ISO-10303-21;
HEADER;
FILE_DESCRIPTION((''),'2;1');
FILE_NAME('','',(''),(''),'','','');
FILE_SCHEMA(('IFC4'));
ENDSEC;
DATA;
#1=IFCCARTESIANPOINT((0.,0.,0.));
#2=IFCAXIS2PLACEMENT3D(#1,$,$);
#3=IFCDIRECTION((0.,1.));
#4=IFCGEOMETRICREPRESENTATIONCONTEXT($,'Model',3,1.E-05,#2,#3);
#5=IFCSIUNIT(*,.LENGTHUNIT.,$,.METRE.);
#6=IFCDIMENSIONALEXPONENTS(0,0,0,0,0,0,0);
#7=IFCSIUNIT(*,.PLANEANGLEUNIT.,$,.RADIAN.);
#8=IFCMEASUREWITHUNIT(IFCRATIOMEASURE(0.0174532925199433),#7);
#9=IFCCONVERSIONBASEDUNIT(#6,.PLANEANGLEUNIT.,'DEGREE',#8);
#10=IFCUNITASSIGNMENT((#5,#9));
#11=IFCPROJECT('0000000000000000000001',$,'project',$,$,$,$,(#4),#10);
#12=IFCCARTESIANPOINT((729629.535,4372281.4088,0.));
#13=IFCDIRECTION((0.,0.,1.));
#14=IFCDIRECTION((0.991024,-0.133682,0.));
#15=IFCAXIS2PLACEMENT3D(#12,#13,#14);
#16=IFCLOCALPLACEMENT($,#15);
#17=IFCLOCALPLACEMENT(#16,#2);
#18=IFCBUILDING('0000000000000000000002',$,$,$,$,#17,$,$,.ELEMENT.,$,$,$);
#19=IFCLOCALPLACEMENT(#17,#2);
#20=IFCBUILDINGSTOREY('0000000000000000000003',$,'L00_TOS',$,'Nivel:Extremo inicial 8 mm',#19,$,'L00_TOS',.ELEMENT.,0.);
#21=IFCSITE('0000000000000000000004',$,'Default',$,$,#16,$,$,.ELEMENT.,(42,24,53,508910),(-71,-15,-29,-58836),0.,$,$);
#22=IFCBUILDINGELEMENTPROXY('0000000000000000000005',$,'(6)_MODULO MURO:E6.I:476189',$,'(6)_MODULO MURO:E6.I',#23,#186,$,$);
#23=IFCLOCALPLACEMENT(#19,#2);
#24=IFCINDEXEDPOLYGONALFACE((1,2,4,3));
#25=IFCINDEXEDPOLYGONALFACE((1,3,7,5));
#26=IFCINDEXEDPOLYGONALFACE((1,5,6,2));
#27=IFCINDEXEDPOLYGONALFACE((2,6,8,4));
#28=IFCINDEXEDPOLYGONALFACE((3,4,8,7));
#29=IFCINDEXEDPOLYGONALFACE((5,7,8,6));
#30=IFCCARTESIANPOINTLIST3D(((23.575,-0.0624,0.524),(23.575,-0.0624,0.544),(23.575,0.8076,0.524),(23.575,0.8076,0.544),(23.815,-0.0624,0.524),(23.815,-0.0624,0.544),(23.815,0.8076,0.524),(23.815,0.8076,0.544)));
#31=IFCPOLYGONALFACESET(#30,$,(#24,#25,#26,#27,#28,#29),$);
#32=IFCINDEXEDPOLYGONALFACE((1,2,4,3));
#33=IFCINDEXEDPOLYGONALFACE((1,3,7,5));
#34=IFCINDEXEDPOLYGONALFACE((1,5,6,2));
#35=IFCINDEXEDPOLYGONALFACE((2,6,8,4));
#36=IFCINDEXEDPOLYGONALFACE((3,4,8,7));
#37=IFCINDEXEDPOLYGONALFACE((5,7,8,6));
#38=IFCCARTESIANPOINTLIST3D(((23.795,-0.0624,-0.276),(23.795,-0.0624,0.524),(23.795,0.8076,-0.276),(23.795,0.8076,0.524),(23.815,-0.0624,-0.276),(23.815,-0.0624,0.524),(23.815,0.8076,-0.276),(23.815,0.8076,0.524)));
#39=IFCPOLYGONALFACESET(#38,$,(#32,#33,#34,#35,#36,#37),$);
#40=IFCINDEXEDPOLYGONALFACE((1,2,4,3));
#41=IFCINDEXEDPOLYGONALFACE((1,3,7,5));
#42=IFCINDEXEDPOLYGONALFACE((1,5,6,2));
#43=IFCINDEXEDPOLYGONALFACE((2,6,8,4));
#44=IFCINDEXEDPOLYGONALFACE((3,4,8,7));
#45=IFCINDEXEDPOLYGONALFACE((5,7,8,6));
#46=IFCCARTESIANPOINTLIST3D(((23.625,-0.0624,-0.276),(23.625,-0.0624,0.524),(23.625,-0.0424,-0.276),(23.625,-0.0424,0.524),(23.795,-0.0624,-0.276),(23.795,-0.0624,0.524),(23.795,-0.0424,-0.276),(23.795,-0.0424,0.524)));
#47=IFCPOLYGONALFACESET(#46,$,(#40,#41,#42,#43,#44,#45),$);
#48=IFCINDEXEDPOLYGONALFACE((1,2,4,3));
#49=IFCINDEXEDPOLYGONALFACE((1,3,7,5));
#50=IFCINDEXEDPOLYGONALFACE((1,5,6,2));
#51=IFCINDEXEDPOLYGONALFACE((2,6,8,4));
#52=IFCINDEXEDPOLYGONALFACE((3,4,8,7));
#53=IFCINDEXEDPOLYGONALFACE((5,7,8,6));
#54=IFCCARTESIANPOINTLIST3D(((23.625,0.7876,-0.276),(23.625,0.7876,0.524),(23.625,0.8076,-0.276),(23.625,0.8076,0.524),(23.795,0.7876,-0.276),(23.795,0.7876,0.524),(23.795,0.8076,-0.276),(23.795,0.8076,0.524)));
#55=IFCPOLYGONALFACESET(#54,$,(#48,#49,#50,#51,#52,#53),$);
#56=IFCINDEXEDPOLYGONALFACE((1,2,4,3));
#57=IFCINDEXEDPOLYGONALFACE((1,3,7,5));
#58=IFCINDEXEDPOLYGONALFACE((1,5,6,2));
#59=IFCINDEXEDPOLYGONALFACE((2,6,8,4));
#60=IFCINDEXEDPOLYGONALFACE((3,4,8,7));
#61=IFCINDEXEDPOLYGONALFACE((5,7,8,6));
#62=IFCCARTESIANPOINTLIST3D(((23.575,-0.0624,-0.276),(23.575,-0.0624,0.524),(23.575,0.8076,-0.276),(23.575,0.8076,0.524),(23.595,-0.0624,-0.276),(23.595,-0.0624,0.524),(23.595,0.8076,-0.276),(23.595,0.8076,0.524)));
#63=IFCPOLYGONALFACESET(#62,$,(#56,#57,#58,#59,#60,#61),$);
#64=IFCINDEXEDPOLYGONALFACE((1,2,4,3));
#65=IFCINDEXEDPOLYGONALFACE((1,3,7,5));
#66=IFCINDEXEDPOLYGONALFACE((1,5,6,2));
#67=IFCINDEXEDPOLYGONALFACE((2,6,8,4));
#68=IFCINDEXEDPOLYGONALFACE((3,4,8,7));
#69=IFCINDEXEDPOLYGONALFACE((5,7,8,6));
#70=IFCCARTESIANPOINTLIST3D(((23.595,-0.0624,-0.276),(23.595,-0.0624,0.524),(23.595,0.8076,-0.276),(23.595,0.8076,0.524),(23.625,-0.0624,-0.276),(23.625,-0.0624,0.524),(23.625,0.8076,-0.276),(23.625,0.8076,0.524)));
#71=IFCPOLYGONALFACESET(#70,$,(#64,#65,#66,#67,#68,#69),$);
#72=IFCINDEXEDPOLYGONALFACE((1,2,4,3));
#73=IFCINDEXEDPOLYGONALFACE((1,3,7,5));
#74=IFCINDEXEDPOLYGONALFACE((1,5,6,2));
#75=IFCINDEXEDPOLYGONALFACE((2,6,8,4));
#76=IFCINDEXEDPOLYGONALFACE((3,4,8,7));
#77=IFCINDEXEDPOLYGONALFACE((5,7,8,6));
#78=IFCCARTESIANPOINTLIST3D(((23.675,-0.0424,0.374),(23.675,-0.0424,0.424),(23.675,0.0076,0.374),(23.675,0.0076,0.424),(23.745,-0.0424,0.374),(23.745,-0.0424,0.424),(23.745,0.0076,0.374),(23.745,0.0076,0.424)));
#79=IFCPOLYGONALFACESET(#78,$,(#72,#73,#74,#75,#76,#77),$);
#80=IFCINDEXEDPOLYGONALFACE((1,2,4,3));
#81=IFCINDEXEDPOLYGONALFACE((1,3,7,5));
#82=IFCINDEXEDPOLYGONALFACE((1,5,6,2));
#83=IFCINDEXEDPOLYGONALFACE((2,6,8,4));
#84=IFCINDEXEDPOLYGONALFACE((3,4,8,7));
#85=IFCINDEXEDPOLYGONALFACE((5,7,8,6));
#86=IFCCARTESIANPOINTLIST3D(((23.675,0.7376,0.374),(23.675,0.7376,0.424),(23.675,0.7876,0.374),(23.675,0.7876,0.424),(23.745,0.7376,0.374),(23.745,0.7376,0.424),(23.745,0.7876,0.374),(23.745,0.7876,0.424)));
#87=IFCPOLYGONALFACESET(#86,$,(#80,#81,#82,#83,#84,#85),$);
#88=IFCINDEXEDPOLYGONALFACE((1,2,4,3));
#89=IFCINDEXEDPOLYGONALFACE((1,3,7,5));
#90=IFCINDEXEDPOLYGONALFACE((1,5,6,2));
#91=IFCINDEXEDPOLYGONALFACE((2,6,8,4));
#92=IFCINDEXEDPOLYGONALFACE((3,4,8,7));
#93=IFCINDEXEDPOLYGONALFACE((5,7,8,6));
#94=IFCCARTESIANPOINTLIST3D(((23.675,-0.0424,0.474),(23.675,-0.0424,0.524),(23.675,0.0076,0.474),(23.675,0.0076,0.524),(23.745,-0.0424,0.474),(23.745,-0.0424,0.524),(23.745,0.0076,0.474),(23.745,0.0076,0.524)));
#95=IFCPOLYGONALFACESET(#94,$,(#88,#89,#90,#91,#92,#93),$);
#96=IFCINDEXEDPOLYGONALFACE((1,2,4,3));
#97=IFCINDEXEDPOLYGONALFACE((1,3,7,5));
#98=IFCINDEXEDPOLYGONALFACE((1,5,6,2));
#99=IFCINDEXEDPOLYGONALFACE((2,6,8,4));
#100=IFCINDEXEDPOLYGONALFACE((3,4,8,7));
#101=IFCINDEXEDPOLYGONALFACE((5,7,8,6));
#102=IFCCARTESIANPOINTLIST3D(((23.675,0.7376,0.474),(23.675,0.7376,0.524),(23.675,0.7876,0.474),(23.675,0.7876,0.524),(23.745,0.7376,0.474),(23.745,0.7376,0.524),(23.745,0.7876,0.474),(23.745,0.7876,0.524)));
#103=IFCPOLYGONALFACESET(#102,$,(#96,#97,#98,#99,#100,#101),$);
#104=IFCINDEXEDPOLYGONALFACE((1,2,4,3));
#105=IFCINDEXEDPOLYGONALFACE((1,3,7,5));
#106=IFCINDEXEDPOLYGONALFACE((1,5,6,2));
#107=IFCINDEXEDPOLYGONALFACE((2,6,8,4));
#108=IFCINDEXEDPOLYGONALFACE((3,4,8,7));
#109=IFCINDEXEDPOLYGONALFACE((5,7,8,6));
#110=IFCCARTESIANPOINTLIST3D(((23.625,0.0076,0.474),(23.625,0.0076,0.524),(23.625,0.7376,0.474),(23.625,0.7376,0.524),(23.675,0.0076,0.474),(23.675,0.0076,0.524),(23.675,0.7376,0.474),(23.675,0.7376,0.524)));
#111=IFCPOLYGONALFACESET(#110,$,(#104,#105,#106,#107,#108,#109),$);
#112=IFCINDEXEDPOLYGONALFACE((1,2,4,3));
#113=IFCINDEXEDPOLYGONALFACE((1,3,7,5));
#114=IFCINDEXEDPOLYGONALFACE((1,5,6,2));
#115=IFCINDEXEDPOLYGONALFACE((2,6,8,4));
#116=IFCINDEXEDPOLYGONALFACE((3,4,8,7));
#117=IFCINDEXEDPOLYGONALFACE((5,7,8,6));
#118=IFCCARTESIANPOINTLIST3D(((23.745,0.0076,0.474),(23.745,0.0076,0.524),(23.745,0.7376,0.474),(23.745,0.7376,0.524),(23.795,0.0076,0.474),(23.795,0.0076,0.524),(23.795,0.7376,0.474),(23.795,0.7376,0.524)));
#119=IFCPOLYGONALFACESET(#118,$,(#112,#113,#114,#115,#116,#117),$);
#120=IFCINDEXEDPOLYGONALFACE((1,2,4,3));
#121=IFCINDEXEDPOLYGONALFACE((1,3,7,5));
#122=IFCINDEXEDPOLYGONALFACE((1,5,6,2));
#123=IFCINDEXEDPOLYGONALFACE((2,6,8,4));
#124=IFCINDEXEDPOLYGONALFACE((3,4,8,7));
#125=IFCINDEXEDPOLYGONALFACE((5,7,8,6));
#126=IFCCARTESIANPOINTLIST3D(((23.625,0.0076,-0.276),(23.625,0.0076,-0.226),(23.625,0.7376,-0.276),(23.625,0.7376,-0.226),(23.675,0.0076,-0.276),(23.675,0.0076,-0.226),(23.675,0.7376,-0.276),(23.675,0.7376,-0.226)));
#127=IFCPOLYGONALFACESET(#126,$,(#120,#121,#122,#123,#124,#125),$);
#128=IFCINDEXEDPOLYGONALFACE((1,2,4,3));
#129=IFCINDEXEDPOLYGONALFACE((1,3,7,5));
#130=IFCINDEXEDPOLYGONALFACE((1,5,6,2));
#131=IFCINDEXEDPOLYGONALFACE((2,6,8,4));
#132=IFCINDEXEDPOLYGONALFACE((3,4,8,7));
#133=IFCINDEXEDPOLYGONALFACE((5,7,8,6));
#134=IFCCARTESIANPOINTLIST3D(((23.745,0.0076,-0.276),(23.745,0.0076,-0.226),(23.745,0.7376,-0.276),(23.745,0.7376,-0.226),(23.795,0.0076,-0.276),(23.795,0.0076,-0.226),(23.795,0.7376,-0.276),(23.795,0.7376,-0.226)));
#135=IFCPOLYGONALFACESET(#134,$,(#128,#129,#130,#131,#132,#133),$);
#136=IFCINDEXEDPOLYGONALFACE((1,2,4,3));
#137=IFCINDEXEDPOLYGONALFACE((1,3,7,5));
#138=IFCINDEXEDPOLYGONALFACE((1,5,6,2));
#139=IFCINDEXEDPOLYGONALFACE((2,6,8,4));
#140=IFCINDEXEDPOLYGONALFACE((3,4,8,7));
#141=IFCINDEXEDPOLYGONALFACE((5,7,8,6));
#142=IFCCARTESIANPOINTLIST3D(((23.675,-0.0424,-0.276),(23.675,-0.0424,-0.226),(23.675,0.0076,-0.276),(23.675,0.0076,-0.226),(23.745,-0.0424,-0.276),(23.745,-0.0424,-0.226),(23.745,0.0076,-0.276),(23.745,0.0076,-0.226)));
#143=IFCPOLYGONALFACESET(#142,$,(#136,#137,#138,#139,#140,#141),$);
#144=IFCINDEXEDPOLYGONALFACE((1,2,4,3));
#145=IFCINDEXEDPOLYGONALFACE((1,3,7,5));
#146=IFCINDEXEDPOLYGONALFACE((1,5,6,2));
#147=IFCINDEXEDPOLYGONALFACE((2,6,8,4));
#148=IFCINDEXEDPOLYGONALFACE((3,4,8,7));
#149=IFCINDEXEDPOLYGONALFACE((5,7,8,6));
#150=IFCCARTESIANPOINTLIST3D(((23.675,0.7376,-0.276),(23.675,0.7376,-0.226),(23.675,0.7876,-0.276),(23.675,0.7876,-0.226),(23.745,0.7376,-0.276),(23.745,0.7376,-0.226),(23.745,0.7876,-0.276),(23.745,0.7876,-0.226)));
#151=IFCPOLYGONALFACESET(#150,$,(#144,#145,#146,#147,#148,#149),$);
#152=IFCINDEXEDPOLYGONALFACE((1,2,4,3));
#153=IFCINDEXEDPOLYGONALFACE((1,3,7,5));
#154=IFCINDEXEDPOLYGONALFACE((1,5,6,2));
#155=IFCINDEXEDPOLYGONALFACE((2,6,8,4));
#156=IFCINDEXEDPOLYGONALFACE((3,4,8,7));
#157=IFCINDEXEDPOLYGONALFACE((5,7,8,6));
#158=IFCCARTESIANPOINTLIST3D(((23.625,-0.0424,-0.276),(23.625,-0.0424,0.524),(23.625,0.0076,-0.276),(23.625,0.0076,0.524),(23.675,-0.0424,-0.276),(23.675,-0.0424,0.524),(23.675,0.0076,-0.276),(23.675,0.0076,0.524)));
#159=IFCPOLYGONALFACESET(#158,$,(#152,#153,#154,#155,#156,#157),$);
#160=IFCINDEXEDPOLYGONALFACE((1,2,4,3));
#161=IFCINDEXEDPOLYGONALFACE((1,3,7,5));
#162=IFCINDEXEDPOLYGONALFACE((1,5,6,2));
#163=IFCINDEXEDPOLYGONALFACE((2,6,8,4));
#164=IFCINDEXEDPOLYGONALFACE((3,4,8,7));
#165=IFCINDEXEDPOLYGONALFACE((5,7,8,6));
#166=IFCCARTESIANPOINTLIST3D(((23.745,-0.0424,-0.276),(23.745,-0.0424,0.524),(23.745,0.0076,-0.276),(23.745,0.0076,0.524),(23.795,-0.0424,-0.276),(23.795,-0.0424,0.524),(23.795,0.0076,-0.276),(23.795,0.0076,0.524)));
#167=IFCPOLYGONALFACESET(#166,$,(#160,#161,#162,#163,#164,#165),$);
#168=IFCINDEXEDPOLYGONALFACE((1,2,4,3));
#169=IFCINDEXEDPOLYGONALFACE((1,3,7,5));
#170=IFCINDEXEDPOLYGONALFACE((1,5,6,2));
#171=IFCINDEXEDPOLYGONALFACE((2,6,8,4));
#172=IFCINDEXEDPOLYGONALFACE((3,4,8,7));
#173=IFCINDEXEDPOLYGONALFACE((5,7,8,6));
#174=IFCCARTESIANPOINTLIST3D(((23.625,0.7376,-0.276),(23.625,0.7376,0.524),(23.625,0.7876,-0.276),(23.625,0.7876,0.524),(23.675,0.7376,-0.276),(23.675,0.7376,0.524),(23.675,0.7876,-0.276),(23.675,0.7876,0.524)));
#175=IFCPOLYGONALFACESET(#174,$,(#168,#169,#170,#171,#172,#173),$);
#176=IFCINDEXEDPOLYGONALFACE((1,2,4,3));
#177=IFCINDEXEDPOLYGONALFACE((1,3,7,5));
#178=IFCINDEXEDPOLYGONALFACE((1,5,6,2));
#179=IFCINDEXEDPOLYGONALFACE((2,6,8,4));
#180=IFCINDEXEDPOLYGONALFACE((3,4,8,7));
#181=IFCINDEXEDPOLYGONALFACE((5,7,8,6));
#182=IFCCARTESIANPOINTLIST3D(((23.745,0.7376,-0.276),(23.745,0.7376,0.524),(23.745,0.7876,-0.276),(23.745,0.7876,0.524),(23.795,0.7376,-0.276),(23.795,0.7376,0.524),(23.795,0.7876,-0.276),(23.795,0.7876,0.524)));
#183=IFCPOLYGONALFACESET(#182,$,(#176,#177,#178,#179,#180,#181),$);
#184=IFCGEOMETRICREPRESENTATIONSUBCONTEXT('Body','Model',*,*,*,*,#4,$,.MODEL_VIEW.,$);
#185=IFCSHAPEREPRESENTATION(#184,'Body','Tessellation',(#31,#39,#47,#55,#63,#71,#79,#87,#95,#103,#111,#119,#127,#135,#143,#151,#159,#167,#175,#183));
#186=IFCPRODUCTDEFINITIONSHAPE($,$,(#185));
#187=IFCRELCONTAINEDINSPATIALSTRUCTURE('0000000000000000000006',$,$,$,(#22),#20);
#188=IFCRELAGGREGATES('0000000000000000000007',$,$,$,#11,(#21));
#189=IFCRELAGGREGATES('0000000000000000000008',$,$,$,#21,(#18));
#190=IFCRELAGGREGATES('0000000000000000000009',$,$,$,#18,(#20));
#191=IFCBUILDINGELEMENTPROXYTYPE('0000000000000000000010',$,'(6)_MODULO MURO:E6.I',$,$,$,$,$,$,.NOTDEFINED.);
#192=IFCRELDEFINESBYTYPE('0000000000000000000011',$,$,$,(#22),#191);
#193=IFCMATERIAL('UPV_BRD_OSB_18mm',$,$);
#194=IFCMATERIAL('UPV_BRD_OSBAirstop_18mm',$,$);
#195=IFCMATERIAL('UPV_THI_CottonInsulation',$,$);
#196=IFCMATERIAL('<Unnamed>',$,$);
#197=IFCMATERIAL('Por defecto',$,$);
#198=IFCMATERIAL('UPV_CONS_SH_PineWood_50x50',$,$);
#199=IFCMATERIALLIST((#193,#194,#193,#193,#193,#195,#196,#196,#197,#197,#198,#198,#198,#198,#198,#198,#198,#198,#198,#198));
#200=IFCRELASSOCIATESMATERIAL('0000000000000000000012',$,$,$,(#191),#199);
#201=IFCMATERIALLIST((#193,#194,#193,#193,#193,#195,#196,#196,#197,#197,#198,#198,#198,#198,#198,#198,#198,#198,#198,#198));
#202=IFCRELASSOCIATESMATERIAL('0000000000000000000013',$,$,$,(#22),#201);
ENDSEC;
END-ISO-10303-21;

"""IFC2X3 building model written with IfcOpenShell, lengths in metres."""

from ifc_helpers import new_model, entity, si_unit, converted_unit, direction, frame, frame_2d, origin, origin_2d_with_axis, place, context, subcontext, project, spatial, rectangle, extrude, source, transform, mapped, material, material_list, type_object, type_shapes, element, save


model = new_model("IFC2X3")

# Units and contexts
model_context = context("Model", 3, precision=1e-05, world=origin(), true_north=direction((0.0, 1.0)))
body_context = subcontext(model_context, "Body", "Model", "MODEL_VIEW")
ifc_project = project(units=[si_unit("LENGTHUNIT", "METRE"), converted_unit("PLANEANGLEUNIT", "DEGREE", entity("IfcRatioMeasure", 0.0174532925199433), si_unit("PLANEANGLEUNIT", "RADIAN"), dimensions=[0, 0, 0, 0, 0, 0, 0])], contexts=[model_context])

# Site, building, storey
site_placement = place(None, frame((729629.535, 4372281.4088, 0.0), z_axis=(0.0, 0.0, 1.0), x_axis=(0.991024, -0.133682, 0.0)))
site = spatial("IfcSite", under=ifc_project, at=site_placement, Name="Default", CompositionType="ELEMENT", RefLatitude=(42, 24, 53, 508910), RefLongitude=(-71, -15, -29, -58836), RefElevation=0.0)
building_placement = place(site_placement, origin())
building = spatial("IfcBuilding", under=site, at=building_placement, CompositionType="ELEMENT")
storey_placement = place(building_placement, origin())
storey = spatial("IfcBuildingStorey", under=building, at=storey_placement, Name="L00_TOS", ObjectType="Nivel:Extremo inicial 8 mm", LongName="L00_TOS", CompositionType="ELEMENT", Elevation=0.0)

# Building element proxy
ifc_material_1 = material(Name="UPV_BRD_OSBAirstop_18mm")
ifc_material_2 = material(Name="UPV_BRD_OSB_18mm")
ifc_material_3 = material(Name="UPV_THI_CottonInsulation")
ifc_material_4 = material(Name="<Unnamed>")
ifc_material_5 = material(Name="UPV_CONS_SH_PineWood_50x50")
ifc_material_6 = material(Name="Por defecto")
ifc_material_list_1 = material_list([ifc_material_2, ifc_material_1, ifc_material_2, ifc_material_2, ifc_material_2, ifc_material_3, ifc_material_4, ifc_material_4, ifc_material_6, ifc_material_6, ifc_material_5, ifc_material_5, ifc_material_5, ifc_material_5, ifc_material_5, ifc_material_5, ifc_material_5, ifc_material_5, ifc_material_5, ifc_material_5])
ifc_material_list_2 = material_list([ifc_material_2, ifc_material_1, ifc_material_2, ifc_material_2, ifc_material_2, ifc_material_3, ifc_material_4, ifc_material_4, ifc_material_6, ifc_material_6, ifc_material_5, ifc_material_5, ifc_material_5, ifc_material_5, ifc_material_5, ifc_material_5, ifc_material_5, ifc_material_5, ifc_material_5, ifc_material_5])
building_element_proxy_type_1 = type_object("IfcBuildingElementProxyType", Name="(6)_MODULO MURO:E6.I", PredefinedType="NOTDEFINED", material=ifc_material_list_2)
shared_shape_1 = source(origin(), body_context, "Body", "SweptSolid", [
    extrude(rectangle(XDim=0.87, YDim=0.24, at=origin_2d_with_axis()), frame((0.0, 0.015, 0.8), z_axis=(0.0, 0.0, 1.0), x_axis=(-1.0, 0.0, 0.0)), (0.0, 0.0, 1.0), 0.02),
    extrude(rectangle(XDim=0.87, YDim=0.02, at=origin_2d_with_axis()), frame((0.0, -0.095, 0.0)), (0.0, 0.0, 1.0), 0.8),
    extrude(rectangle(XDim=0.17, YDim=0.02, at=frame_2d((0.0, 0.0), x_axis=(1.0, 0.0))), frame((-0.425, 0.0, 0.0), z_axis=(0.0, 0.0, 1.0), x_axis=(0.0, -1.0, 0.0)), (0.0, 0.0, 1.0), 0.8),
    extrude(rectangle(XDim=0.17, YDim=0.02, at=origin_2d_with_axis()), frame((0.425, 0.0, 0.0), z_axis=(0.0, 0.0, 1.0), x_axis=(0.0, -1.0, 0.0)), (0.0, 0.0, 1.0), 0.8),
    extrude(rectangle(XDim=0.87, YDim=0.02, at=origin_2d_with_axis()), frame((0.0, 0.125, 0.0), z_axis=(0.0, 0.0, 1.0), x_axis=(-1.0, 0.0, 0.0)), (0.0, 0.0, 1.0), 0.8),
    extrude(rectangle(XDim=0.87, YDim=0.03, at=origin_2d_with_axis()), frame((0.0, 0.1, 0.0), z_axis=(0.0, 0.0, 1.0), x_axis=(-1.0, 0.0, 0.0)), (0.0, 0.0, 1.0), 0.8),
    extrude(rectangle(XDim=0.07, YDim=0.05, at=origin_2d_with_axis()), frame((-0.39, 0.0, 0.65), z_axis=(0.0, 0.0, 1.0), x_axis=(0.0, 1.0, 0.0)), (0.0, 0.0, 1.0), 0.05),
    extrude(rectangle(XDim=0.07, YDim=0.05, at=origin_2d_with_axis()), frame((0.39, 0.0, 0.65), z_axis=(0.0, 0.0, 1.0), x_axis=(0.0, 1.0, 0.0)), (0.0, 0.0, 1.0), 0.05),
    extrude(rectangle(XDim=0.07, YDim=0.05, at=origin_2d_with_axis()), frame((-0.39, 0.0, 0.75), z_axis=(0.0, 0.0, 1.0), x_axis=(0.0, -1.0, 0.0)), (0.0, 0.0, 1.0), 0.05),
    extrude(rectangle(XDim=0.07, YDim=0.05, at=frame_2d((0.0, 0.0), x_axis=(1.0, 0.0))), frame((0.39, 0.0, 0.75), z_axis=(0.0, 0.0, 1.0), x_axis=(0.0, -1.0, 0.0)), (0.0, 0.0, 1.0), 0.05),
    extrude(rectangle(XDim=0.73, YDim=0.05, at=origin_2d_with_axis()), frame((0.0, 0.06, 0.75), z_axis=(0.0, 0.0, 1.0), x_axis=(-1.0, 0.0, 0.0)), (0.0, 0.0, 1.0), 0.05),
    extrude(rectangle(XDim=0.05, YDim=0.73, at=origin_2d_with_axis()), frame((0.0, -0.06, 0.75), z_axis=(0.0, 0.0, 1.0), x_axis=(0.0, -1.0, 0.0)), (0.0, 0.0, 1.0), 0.05),
    extrude(rectangle(XDim=0.05, YDim=0.73, at=origin_2d_with_axis()), frame((0.0, 0.06, 0.0), z_axis=(0.0, 0.0, 1.0), x_axis=(0.0, -1.0, 0.0)), (0.0, 0.0, 1.0), 0.05),
    extrude(rectangle(XDim=0.05, YDim=0.73, at=origin_2d_with_axis()), frame((0.0, -0.06, 0.0), z_axis=(0.0, 0.0, 1.0), x_axis=(0.0, -1.0, 0.0)), (0.0, 0.0, 1.0), 0.05),
    extrude(rectangle(XDim=0.07, YDim=0.05, at=origin_2d_with_axis()), frame((-0.39, 0.0, 0.0), z_axis=(0.0, 0.0, 1.0), x_axis=(0.0, -1.0, 0.0)), (0.0, 0.0, 1.0), 0.05),
    extrude(rectangle(XDim=0.05, YDim=0.07, at=origin_2d_with_axis()), frame((0.39, 0.0, 0.0), z_axis=(0.0, 0.0, 1.0), x_axis=(-1.0, 0.0, 0.0)), (0.0, 0.0, 1.0), 0.05),
    extrude(rectangle(XDim=0.05, YDim=0.05, at=origin_2d_with_axis()), frame((-0.39, 0.06, 0.0), z_axis=(0.0, 0.0, 1.0), x_axis=(0.0, -1.0, 0.0)), (0.0, 0.0, 1.0), 0.8),
    extrude(rectangle(XDim=0.05, YDim=0.05, at=origin_2d_with_axis()), frame((-0.39, -0.06, 0.0), z_axis=(0.0, 0.0, 1.0), x_axis=(0.0, -1.0, 0.0)), (0.0, 0.0, 1.0), 0.8),
    extrude(rectangle(XDim=0.05, YDim=0.05, at=origin_2d_with_axis()), frame((0.39, 0.06, 0.0), z_axis=(0.0, 0.0, 1.0), x_axis=(0.0, -1.0, 0.0)), (0.0, 0.0, 1.0), 0.8),
    extrude(rectangle(XDim=0.05, YDim=0.05, at=origin_2d_with_axis()), frame((0.39, -0.06, 0.0), z_axis=(0.0, 0.0, 1.0), x_axis=(0.0, -1.0, 0.0)), (0.0, 0.0, 1.0), 0.8),
])
type_shapes(building_element_proxy_type_1, [shared_shape_1])
proxy_1_placement = place(storey_placement, frame((23.71, 0.3726, -0.276), z_axis=(0.0, 0.0, 1.0), x_axis=(0.0, 1.0, 0.0)))
element("IfcBuildingElementProxy", 1, at=proxy_1_placement, inside=storey, type_object=building_element_proxy_type_1, material=ifc_material_list_1, Name="(6)_MODULO MURO:E6.I:476189", ObjectType="(6)_MODULO MURO:E6.I", context=body_context, shape_type="MappedRepresentation", body=[
    mapped(shared_shape_1, transform((0.0, 0.0, 0.0), scale=1.0)),
])

save(model, "model.ifc")
